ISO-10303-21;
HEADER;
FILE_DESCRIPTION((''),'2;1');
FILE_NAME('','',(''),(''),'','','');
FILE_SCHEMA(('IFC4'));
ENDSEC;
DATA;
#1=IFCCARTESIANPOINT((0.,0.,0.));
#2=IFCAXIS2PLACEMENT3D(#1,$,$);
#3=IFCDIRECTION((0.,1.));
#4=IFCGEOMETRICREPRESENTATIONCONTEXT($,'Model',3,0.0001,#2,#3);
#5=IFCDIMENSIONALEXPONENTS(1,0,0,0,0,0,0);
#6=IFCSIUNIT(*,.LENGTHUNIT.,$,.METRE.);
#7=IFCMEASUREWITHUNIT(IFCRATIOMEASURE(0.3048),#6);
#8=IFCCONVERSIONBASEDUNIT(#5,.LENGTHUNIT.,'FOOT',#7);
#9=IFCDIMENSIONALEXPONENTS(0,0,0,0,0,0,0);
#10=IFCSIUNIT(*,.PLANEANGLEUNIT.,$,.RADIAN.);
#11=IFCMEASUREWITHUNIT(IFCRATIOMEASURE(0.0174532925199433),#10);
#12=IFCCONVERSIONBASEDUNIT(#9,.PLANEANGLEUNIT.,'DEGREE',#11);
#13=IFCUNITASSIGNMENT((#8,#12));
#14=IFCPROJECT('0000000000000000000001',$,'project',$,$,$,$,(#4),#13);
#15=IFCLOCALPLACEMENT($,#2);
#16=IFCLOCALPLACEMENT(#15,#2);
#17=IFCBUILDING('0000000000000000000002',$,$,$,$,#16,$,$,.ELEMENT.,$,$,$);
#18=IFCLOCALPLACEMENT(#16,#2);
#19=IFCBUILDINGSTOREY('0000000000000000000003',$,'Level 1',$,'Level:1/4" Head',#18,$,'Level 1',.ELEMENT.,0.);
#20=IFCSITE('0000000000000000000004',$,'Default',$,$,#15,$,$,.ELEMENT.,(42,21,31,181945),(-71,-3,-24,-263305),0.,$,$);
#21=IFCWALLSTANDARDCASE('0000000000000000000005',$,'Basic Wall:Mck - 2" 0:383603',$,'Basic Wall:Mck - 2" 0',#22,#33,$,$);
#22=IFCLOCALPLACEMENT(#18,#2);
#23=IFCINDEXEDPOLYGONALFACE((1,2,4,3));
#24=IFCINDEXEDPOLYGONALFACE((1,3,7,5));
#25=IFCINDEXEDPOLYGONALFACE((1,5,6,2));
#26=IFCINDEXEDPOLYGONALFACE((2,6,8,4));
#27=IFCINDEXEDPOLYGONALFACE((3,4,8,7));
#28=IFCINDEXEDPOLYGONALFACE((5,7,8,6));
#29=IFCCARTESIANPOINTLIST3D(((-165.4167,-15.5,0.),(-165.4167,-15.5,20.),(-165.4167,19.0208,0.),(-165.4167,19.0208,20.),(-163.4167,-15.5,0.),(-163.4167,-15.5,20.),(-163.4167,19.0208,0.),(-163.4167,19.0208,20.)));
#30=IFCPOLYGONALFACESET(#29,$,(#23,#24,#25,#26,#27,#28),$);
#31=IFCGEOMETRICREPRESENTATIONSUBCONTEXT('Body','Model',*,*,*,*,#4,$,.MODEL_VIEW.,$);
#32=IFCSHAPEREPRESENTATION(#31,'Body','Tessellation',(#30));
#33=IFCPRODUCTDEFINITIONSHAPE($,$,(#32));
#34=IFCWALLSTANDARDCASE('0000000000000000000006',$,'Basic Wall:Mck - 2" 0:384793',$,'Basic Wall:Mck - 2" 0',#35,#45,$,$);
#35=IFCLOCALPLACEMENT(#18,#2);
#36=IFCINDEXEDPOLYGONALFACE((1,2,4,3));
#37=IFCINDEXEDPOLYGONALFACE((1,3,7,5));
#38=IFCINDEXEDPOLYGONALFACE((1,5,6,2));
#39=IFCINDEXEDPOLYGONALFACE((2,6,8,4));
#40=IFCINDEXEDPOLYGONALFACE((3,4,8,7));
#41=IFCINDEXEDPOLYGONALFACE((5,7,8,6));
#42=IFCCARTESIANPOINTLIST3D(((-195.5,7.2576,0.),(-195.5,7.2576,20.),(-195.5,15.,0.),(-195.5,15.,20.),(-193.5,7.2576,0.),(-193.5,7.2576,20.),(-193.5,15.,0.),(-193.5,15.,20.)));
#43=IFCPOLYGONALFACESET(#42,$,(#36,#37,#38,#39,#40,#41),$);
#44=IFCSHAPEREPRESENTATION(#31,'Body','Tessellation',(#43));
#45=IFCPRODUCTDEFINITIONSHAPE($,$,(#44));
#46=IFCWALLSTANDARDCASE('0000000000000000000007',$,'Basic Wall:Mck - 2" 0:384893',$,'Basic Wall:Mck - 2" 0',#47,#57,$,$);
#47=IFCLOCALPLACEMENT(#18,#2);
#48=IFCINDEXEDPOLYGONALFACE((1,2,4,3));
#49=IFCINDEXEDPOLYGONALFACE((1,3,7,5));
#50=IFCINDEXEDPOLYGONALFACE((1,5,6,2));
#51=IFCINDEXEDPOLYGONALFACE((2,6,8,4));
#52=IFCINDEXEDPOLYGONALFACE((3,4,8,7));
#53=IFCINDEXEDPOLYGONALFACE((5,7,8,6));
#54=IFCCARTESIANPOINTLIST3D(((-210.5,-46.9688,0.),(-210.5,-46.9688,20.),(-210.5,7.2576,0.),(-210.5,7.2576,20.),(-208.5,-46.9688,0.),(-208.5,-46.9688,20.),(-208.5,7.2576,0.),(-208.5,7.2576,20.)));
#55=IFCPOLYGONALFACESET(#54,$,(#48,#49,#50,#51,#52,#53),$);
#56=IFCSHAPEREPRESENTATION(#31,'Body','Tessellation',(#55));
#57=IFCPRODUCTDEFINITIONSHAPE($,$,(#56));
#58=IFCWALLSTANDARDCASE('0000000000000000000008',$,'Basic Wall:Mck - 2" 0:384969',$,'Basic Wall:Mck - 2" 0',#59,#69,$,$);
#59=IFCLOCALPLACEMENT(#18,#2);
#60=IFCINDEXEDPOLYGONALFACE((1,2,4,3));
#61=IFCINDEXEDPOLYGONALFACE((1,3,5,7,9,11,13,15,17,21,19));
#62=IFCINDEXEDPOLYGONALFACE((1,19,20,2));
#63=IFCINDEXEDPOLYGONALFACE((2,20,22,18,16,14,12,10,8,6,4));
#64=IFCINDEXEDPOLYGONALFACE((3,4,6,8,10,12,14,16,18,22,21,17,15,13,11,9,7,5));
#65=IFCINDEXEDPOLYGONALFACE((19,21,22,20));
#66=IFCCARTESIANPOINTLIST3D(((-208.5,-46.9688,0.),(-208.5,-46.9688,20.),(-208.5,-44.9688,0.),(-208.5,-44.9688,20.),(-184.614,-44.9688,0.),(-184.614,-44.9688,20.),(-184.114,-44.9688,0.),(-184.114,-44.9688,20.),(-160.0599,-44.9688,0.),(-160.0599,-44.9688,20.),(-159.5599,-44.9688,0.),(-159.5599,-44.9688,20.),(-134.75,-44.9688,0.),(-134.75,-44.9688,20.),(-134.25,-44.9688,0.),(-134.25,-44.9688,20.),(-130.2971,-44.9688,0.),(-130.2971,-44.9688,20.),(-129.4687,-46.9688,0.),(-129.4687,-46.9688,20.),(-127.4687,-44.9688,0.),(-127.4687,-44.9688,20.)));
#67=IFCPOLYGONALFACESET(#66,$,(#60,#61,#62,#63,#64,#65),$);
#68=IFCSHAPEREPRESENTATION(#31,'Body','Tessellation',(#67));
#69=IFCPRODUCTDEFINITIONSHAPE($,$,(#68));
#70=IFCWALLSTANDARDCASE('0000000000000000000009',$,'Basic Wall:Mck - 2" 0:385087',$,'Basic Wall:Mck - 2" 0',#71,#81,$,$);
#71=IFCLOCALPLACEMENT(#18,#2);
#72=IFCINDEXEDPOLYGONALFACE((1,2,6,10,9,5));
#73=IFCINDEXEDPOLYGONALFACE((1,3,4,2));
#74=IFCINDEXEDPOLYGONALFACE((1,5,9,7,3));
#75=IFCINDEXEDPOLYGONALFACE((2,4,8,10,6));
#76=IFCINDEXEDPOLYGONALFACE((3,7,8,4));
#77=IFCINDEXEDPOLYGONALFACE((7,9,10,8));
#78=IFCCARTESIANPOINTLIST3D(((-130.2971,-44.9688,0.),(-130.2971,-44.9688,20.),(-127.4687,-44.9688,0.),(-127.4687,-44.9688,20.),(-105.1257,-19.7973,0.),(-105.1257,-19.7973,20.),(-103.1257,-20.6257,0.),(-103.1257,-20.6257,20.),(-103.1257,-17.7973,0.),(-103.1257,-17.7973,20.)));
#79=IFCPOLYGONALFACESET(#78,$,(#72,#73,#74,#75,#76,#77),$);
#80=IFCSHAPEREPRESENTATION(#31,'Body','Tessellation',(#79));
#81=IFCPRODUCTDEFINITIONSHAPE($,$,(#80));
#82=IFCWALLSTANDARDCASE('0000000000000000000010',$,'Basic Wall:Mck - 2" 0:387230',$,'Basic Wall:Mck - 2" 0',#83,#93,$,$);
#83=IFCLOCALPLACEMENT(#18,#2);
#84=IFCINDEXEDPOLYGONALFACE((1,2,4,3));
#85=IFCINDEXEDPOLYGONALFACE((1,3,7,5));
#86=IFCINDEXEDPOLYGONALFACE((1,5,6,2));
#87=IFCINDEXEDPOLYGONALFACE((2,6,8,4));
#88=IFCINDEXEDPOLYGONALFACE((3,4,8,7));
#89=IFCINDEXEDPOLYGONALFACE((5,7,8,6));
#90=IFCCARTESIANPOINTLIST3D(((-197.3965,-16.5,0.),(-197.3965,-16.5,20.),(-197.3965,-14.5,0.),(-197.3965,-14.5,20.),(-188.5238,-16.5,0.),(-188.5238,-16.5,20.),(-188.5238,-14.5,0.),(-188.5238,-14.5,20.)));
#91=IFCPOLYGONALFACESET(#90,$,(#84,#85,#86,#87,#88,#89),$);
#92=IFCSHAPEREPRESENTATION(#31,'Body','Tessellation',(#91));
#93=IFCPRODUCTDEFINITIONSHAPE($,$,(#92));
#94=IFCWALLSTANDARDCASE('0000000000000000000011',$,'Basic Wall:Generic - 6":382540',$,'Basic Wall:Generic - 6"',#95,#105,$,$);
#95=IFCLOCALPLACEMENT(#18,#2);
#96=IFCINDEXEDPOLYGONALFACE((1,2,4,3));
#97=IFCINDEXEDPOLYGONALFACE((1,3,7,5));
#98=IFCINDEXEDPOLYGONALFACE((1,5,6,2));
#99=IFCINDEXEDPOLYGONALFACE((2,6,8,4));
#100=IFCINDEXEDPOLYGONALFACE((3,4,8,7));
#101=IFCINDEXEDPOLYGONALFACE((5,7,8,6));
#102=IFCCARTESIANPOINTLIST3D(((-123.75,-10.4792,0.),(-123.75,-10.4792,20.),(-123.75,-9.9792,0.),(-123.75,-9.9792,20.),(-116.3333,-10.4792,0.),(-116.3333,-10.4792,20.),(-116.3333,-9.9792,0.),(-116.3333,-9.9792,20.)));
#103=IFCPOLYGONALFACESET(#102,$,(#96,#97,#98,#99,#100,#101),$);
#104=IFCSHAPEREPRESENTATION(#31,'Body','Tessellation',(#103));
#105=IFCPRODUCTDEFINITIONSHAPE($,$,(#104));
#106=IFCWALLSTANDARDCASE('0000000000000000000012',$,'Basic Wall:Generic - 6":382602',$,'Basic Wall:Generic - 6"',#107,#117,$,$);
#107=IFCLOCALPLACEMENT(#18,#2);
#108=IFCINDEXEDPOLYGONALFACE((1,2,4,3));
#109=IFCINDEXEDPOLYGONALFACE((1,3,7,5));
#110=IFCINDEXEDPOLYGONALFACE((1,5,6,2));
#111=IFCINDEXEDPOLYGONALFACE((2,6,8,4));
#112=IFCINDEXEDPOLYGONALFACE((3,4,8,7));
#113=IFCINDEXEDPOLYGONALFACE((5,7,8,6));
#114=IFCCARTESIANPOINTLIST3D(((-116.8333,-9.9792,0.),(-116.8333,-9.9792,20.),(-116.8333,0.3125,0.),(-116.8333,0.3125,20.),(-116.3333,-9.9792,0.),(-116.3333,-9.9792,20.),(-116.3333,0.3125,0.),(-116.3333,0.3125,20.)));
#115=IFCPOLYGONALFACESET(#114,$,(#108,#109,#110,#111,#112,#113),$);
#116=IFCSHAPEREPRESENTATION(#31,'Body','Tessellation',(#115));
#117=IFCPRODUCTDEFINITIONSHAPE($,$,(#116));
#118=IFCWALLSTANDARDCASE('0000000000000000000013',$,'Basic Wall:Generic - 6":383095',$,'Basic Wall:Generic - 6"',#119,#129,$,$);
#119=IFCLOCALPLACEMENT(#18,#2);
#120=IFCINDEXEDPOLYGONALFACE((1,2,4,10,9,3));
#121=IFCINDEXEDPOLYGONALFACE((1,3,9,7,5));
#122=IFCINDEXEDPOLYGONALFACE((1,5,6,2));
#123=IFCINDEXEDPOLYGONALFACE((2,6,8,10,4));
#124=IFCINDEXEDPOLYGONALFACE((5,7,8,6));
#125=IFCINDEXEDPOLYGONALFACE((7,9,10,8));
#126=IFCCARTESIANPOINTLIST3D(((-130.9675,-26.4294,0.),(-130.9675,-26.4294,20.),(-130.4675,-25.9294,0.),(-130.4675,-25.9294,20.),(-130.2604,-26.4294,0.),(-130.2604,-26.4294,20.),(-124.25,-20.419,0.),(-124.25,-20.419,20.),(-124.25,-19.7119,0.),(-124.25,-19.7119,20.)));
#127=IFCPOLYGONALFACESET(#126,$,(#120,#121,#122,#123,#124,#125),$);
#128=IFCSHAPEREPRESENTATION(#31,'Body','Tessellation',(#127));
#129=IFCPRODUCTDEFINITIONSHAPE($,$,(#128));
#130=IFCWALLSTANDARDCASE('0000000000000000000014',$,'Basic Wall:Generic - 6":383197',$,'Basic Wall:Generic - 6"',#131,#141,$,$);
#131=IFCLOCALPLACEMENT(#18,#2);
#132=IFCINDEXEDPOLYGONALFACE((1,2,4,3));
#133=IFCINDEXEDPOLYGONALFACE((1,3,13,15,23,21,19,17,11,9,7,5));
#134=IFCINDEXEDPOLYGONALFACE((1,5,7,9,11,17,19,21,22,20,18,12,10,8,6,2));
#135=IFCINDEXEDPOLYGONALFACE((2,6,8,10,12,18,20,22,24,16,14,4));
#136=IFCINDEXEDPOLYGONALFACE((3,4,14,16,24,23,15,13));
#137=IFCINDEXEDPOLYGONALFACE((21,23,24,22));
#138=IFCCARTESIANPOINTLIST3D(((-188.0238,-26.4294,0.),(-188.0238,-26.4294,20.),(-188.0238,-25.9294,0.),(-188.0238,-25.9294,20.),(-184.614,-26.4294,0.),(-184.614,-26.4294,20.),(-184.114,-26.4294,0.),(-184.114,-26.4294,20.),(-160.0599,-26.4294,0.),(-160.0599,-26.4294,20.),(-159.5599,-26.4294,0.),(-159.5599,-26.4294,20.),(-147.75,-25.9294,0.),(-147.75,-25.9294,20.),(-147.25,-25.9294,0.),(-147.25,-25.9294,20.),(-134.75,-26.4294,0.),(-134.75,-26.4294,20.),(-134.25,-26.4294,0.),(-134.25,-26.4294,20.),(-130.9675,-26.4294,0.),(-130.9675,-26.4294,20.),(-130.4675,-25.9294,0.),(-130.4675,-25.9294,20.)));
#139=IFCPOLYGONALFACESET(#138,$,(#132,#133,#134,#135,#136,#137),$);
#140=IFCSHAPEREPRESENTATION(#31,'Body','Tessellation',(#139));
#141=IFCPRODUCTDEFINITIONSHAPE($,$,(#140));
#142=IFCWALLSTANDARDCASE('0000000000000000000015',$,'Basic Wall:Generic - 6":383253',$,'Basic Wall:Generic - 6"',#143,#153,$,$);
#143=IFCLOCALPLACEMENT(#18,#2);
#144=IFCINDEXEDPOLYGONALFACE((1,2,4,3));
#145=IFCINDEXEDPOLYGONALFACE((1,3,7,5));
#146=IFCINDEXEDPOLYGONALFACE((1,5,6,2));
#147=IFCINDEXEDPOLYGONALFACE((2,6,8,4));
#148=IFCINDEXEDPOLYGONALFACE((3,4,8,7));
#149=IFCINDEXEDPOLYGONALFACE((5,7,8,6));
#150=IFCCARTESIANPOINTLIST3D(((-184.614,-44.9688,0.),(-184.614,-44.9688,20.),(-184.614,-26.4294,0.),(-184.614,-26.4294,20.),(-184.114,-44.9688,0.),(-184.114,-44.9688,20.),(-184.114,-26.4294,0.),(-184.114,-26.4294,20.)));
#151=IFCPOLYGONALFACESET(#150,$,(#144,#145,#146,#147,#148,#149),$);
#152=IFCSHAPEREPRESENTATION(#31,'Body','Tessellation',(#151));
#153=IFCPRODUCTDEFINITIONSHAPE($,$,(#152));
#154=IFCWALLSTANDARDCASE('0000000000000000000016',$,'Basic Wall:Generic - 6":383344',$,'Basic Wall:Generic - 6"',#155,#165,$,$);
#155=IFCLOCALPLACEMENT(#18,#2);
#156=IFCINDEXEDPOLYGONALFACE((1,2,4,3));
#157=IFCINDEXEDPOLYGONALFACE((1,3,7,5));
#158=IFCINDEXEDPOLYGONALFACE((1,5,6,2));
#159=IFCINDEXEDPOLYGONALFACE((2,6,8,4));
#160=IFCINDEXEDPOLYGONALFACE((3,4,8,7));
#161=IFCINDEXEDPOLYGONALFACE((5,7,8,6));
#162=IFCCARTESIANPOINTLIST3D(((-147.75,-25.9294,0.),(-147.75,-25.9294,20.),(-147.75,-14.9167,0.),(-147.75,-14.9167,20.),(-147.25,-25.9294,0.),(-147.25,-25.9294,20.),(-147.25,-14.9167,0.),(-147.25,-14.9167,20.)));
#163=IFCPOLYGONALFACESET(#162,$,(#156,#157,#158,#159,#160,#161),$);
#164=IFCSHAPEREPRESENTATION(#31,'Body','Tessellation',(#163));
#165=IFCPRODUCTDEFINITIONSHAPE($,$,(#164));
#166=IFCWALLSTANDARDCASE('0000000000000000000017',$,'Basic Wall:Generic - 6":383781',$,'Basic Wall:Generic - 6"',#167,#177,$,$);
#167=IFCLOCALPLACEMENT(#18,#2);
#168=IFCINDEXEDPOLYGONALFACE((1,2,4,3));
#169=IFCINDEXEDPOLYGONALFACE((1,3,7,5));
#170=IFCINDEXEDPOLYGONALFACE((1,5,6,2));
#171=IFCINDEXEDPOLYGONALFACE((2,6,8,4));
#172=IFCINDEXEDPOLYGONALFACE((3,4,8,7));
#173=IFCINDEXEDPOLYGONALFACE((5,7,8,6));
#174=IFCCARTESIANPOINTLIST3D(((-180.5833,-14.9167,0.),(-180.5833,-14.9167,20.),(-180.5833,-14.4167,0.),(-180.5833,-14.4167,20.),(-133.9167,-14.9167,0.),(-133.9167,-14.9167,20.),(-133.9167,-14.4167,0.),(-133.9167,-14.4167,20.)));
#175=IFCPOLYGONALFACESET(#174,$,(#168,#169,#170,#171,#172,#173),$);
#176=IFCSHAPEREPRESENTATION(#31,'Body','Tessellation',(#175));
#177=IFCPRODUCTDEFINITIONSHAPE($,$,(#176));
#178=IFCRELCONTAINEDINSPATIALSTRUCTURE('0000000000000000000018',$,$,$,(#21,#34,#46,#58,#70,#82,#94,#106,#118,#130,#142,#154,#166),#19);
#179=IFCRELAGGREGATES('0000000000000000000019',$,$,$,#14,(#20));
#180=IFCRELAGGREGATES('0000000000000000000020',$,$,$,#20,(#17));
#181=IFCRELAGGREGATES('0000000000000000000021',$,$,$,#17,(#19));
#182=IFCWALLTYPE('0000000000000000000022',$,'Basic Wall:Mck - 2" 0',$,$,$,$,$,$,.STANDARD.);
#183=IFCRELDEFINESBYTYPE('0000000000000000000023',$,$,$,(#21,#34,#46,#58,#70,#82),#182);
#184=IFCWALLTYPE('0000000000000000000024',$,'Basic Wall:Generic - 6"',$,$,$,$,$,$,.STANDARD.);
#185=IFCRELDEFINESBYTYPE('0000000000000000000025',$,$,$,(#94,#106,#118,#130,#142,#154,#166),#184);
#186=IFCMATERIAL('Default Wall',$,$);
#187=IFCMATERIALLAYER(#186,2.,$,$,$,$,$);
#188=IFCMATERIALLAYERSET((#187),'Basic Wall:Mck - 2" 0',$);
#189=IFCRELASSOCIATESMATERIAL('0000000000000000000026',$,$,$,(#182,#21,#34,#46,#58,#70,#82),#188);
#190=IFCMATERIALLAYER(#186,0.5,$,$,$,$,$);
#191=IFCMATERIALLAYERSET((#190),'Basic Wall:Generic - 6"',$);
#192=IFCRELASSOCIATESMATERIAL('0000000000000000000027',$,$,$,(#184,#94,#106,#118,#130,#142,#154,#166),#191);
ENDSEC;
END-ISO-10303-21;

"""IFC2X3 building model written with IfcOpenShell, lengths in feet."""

from ifc_helpers import new_model, entity, si_unit, converted_unit, direction, frame, frame_2d, origin, place, context, subcontext, project, spatial, polyline, rectangle, outline, extrude, material, layer, layer_set, layer_usage, type_object, element, save


model = new_model("IFC2X3")

# Units and contexts
model_context = context("Model", 3, precision=0.0001, world=origin(), true_north=direction((0.0, 1.0)))
body_context = subcontext(model_context, "Body", "Model", "MODEL_VIEW")
ifc_project = project(units=[converted_unit("LENGTHUNIT", "FOOT", entity("IfcRatioMeasure", 0.3048), si_unit("LENGTHUNIT", "METRE"), dimensions=[1, 0, 0, 0, 0, 0, 0]), converted_unit("PLANEANGLEUNIT", "DEGREE", entity("IfcRatioMeasure", 0.0174532925199433), si_unit("PLANEANGLEUNIT", "RADIAN"), dimensions=[0, 0, 0, 0, 0, 0, 0])], contexts=[model_context])

# Site, building, storey
site_placement = place(None, origin())
site = spatial("IfcSite", under=ifc_project, at=site_placement, Name="Default", CompositionType="ELEMENT", RefLatitude=(42, 21, 31, 181945), RefLongitude=(-71, -3, -24, -263305), RefElevation=0.0)
building_placement = place(site_placement, origin())
building = spatial("IfcBuilding", under=site, at=building_placement, CompositionType="ELEMENT")
storey_placement = place(building_placement, origin())
storey = spatial("IfcBuildingStorey", under=building, at=storey_placement, Name="Level 1", ObjectType="Level:1/4\" Head", LongName="Level 1", CompositionType="ELEMENT", Elevation=0.0)

# Walls
ifc_material = material(Name="Default Wall")
ifc_layer_1 = layer(ifc_material, 2.0)
ifc_layer_set_1 = layer_set([ifc_layer_1], Name="Basic Wall:Mck - 2\" 0")
ifc_layer_usage_1 = layer_usage(ifc_layer_set_1, "AXIS2", "NEGATIVE", 1.0)
wall_type_1 = type_object("IfcWallType", Name="Basic Wall:Mck - 2\" 0", PredefinedType="STANDARD", material=ifc_layer_set_1)
wall_1_placement = place(storey_placement, frame((-164.4167, -15.5, 0.0), z_axis=(0.0, 0.0, 1.0), x_axis=(0.0, 1.0, 0.0)))
element("IfcWallStandardCase", 1, at=wall_1_placement, inside=storey, type_object=wall_type_1, material=ifc_layer_usage_1, Name="Basic Wall:Mck - 2\" 0:383603", ObjectType="Basic Wall:Mck - 2\" 0", context=body_context, shape_type="SweptSolid", body=[
    extrude(rectangle(XDim=34.5208, YDim=2.0, at=frame_2d((17.2604, 0.0), x_axis=(-1.0, 0.0))), origin(), (0.0, 0.0, 1.0), 20.0),
])
ifc_layer_usage_2 = layer_usage(ifc_layer_set_1, "AXIS2", "NEGATIVE", 1.0)
wall_2_placement = place(storey_placement, frame((-194.5, 7.2576, 0.0), z_axis=(0.0, 0.0, 1.0), x_axis=(0.0, 1.0, 0.0)))
element("IfcWallStandardCase", 2, at=wall_2_placement, inside=storey, type_object=wall_type_1, material=ifc_layer_usage_2, Name="Basic Wall:Mck - 2\" 0:384793", ObjectType="Basic Wall:Mck - 2\" 0", context=body_context, shape_type="SweptSolid", body=[
    extrude(rectangle(XDim=7.7424, YDim=2.0, at=frame_2d((3.8712, 0.0), x_axis=(-1.0, 0.0))), origin(), (0.0, 0.0, 1.0), 20.0),
])
ifc_layer_usage_3 = layer_usage(ifc_layer_set_1, "AXIS2", "NEGATIVE", 1.0)
wall_3_placement = place(storey_placement, frame((-209.5, 7.2576, 0.0), z_axis=(0.0, 0.0, 1.0), x_axis=(0.0, -1.0, 0.0)))
element("IfcWallStandardCase", 3, at=wall_3_placement, inside=storey, type_object=wall_type_1, material=ifc_layer_usage_3, Name="Basic Wall:Mck - 2\" 0:384893", ObjectType="Basic Wall:Mck - 2\" 0", context=body_context, shape_type="SweptSolid", body=[
    extrude(rectangle(XDim=54.2264, YDim=2.0, at=frame_2d((27.1132, 0.0), x_axis=(-1.0, 0.0))), origin(), (0.0, 0.0, 1.0), 20.0),
])
ifc_layer_usage_4 = layer_usage(ifc_layer_set_1, "AXIS2", "NEGATIVE", 1.0)
wall_4_placement = place(storey_placement, frame((-208.5, -45.9688, 0.0)))
element("IfcWallStandardCase", 4, at=wall_4_placement, inside=storey, type_object=wall_type_1, material=ifc_layer_usage_4, Name="Basic Wall:Mck - 2\" 0:384969", ObjectType="Basic Wall:Mck - 2\" 0", context=body_context, shape_type="SweptSolid", body=[
    extrude(outline(polyline([(79.0313, -1.0), (81.0313, 1.0), (78.2029, 1.0), (74.25, 1.0), (73.75, 1.0), (48.9401, 1.0), (48.4401, 1.0), (24.386, 1.0), (23.886, 1.0), (0.0, 1.0), (0.0, -1.0), (79.0313, -1.0)])), origin(), (0.0, 0.0, 1.0), 20.0),
])
ifc_layer_usage_5 = layer_usage(ifc_layer_set_1, "AXIS2", "NEGATIVE", 1.0)
wall_5_placement = place(storey_placement, frame((-129.59, -45.6759, 0.0), z_axis=(0.0, 0.0, 1.0), x_axis=(0.707107, 0.707107, 0.0)))
element("IfcWallStandardCase", 5, at=wall_5_placement, inside=storey, type_object=wall_type_1, material=ifc_layer_usage_5, Name="Basic Wall:Mck - 2\" 0:385087", ObjectType="Basic Wall:Mck - 2\" 0", context=body_context, shape_type="SweptSolid", body=[
    extrude(outline(polyline([(36.4263, -1.0), (38.4263, 1.0), (35.5979, 1.0), (0.0, 1.0), (2.0, -1.0), (36.4263, -1.0)])), origin(), (0.0, 0.0, 1.0), 20.0),
])
ifc_layer_usage_6 = layer_usage(ifc_layer_set_1, "AXIS2", "NEGATIVE", 1.0)
wall_6_placement = place(storey_placement, frame((-188.5238, -15.5, 0.0), z_axis=(0.0, 0.0, 1.0), x_axis=(-1.0, 0.0, 0.0)))
element("IfcWallStandardCase", 6, at=wall_6_placement, inside=storey, type_object=wall_type_1, material=ifc_layer_usage_6, Name="Basic Wall:Mck - 2\" 0:387230", ObjectType="Basic Wall:Mck - 2\" 0", context=body_context, shape_type="SweptSolid", body=[
    extrude(rectangle(XDim=8.8727, YDim=2.0, at=frame_2d((4.4364, 0.0), x_axis=(-1.0, 0.0))), origin(), (0.0, 0.0, 1.0), 20.0),
])
ifc_layer_2 = layer(ifc_material, 0.5)
ifc_layer_set_2 = layer_set([ifc_layer_2], Name="Basic Wall:Generic - 6\"")
ifc_layer_usage_7 = layer_usage(ifc_layer_set_2, "AXIS2", "NEGATIVE", 0.25)
wall_type_2 = type_object("IfcWallType", Name="Basic Wall:Generic - 6\"", PredefinedType="STANDARD", material=ifc_layer_set_2)
wall_7_placement = place(storey_placement, frame((-123.75, -10.2292, 0.0)))
element("IfcWallStandardCase", 7, at=wall_7_placement, inside=storey, type_object=wall_type_2, material=ifc_layer_usage_7, Name="Basic Wall:Generic - 6\":382540", ObjectType="Basic Wall:Generic - 6\"", context=body_context, shape_type="SweptSolid", body=[
    extrude(rectangle(XDim=7.4167, YDim=0.5, at=frame_2d((3.7083, 0.0), x_axis=(-1.0, 0.0))), origin(), (0.0, 0.0, 1.0), 20.0),
])
ifc_layer_usage_8 = layer_usage(ifc_layer_set_2, "AXIS2", "NEGATIVE", 0.25)
wall_8_placement = place(storey_placement, frame((-116.5833, -9.9792, 0.0), z_axis=(0.0, 0.0, 1.0), x_axis=(0.0, 1.0, 0.0)))
element("IfcWallStandardCase", 8, at=wall_8_placement, inside=storey, type_object=wall_type_2, material=ifc_layer_usage_8, Name="Basic Wall:Generic - 6\":382602", ObjectType="Basic Wall:Generic - 6\"", context=body_context, shape_type="SweptSolid", body=[
    extrude(rectangle(XDim=10.2917, YDim=0.5, at=frame_2d((5.1458, 0.0), x_axis=(-1.0, 0.0))), origin(), (0.0, 0.0, 1.0), 20.0),
])
ifc_layer_usage_9 = layer_usage(ifc_layer_set_2, "AXIS2", "NEGATIVE", 0.25)
wall_9_placement = place(storey_placement, frame((-124.0732, -19.8887, 0.0), z_axis=(0.0, 0.0, 1.0), x_axis=(-0.707107, -0.707107, 0.0)))
element("IfcWallStandardCase", 9, at=wall_9_placement, inside=storey, type_object=wall_type_2, material=ifc_layer_usage_9, Name="Basic Wall:Generic - 6\":383095", ObjectType="Basic Wall:Generic - 6\"", context=body_context, shape_type="SweptSolid", body=[
    extrude(outline(polyline([(9.5, -0.25), (9.0, 0.25), (0.5, 0.25), (0.0, -0.25), (8.7929, -0.25), (9.5, -0.25)])), origin(), (0.0, 0.0, 1.0), 20.0),
])
ifc_layer_usage_10 = layer_usage(ifc_layer_set_2, "AXIS2", "NEGATIVE", 0.25)
wall_10_placement = place(storey_placement, frame((-130.4675, -26.1794, 0.0), z_axis=(0.0, 0.0, 1.0), x_axis=(-1.0, 0.0, 0.0)))
element("IfcWallStandardCase", 10, at=wall_10_placement, inside=storey, type_object=wall_type_2, material=ifc_layer_usage_10, Name="Basic Wall:Generic - 6\":383197", ObjectType="Basic Wall:Generic - 6\"", context=body_context, shape_type="SweptSolid", body=[
    extrude(outline(polyline([(57.5562, -0.25), (57.5562, 0.25), (54.1464, 0.25), (53.6464, 0.25), (29.5924, 0.25), (29.0924, 0.25), (4.2825, 0.25), (3.7825, 0.25), (0.5, 0.25), (0.0, -0.25), (16.7825, -0.25), (17.2825, -0.25), (57.5562, -0.25)])), origin(), (0.0, 0.0, 1.0), 20.0),
])
ifc_layer_usage_11 = layer_usage(ifc_layer_set_2, "AXIS2", "NEGATIVE", 0.25)
wall_11_placement = place(storey_placement, frame((-184.364, -26.4294, 0.0), z_axis=(0.0, 0.0, 1.0), x_axis=(0.0, -1.0, 0.0)))
element("IfcWallStandardCase", 11, at=wall_11_placement, inside=storey, type_object=wall_type_2, material=ifc_layer_usage_11, Name="Basic Wall:Generic - 6\":383253", ObjectType="Basic Wall:Generic - 6\"", context=body_context, shape_type="SweptSolid", body=[
    extrude(rectangle(XDim=18.5394, YDim=0.5, at=frame_2d((9.2697, 0.0), x_axis=(-1.0, 0.0))), origin(), (0.0, 0.0, 1.0), 20.0),
])
ifc_layer_usage_12 = layer_usage(ifc_layer_set_2, "AXIS2", "NEGATIVE", 0.25)
wall_12_placement = place(storey_placement, frame((-147.5, -14.9167, 0.0), z_axis=(0.0, 0.0, 1.0), x_axis=(0.0, -1.0, 0.0)))
element("IfcWallStandardCase", 12, at=wall_12_placement, inside=storey, type_object=wall_type_2, material=ifc_layer_usage_12, Name="Basic Wall:Generic - 6\":383344", ObjectType="Basic Wall:Generic - 6\"", context=body_context, shape_type="SweptSolid", body=[
    extrude(rectangle(XDim=11.0127, YDim=0.5, at=frame_2d((5.5064, 0.0), x_axis=(-1.0, 0.0))), origin(), (0.0, 0.0, 1.0), 20.0),
])
ifc_layer_usage_13 = layer_usage(ifc_layer_set_2, "AXIS2", "NEGATIVE", 0.25)
wall_13_placement = place(storey_placement, frame((-133.9167, -14.6667, 0.0), z_axis=(0.0, 0.0, 1.0), x_axis=(-1.0, 0.0, 0.0)))
element("IfcWallStandardCase", 13, at=wall_13_placement, inside=storey, type_object=wall_type_2, material=ifc_layer_usage_13, Name="Basic Wall:Generic - 6\":383781", ObjectType="Basic Wall:Generic - 6\"", context=body_context, shape_type="SweptSolid", body=[
    extrude(rectangle(XDim=46.6667, YDim=0.5, at=frame_2d((23.3333, 0.0), x_axis=(-1.0, 0.0))), origin(), (0.0, 0.0, 1.0), 20.0),
])

save(model, "model.ifc")
